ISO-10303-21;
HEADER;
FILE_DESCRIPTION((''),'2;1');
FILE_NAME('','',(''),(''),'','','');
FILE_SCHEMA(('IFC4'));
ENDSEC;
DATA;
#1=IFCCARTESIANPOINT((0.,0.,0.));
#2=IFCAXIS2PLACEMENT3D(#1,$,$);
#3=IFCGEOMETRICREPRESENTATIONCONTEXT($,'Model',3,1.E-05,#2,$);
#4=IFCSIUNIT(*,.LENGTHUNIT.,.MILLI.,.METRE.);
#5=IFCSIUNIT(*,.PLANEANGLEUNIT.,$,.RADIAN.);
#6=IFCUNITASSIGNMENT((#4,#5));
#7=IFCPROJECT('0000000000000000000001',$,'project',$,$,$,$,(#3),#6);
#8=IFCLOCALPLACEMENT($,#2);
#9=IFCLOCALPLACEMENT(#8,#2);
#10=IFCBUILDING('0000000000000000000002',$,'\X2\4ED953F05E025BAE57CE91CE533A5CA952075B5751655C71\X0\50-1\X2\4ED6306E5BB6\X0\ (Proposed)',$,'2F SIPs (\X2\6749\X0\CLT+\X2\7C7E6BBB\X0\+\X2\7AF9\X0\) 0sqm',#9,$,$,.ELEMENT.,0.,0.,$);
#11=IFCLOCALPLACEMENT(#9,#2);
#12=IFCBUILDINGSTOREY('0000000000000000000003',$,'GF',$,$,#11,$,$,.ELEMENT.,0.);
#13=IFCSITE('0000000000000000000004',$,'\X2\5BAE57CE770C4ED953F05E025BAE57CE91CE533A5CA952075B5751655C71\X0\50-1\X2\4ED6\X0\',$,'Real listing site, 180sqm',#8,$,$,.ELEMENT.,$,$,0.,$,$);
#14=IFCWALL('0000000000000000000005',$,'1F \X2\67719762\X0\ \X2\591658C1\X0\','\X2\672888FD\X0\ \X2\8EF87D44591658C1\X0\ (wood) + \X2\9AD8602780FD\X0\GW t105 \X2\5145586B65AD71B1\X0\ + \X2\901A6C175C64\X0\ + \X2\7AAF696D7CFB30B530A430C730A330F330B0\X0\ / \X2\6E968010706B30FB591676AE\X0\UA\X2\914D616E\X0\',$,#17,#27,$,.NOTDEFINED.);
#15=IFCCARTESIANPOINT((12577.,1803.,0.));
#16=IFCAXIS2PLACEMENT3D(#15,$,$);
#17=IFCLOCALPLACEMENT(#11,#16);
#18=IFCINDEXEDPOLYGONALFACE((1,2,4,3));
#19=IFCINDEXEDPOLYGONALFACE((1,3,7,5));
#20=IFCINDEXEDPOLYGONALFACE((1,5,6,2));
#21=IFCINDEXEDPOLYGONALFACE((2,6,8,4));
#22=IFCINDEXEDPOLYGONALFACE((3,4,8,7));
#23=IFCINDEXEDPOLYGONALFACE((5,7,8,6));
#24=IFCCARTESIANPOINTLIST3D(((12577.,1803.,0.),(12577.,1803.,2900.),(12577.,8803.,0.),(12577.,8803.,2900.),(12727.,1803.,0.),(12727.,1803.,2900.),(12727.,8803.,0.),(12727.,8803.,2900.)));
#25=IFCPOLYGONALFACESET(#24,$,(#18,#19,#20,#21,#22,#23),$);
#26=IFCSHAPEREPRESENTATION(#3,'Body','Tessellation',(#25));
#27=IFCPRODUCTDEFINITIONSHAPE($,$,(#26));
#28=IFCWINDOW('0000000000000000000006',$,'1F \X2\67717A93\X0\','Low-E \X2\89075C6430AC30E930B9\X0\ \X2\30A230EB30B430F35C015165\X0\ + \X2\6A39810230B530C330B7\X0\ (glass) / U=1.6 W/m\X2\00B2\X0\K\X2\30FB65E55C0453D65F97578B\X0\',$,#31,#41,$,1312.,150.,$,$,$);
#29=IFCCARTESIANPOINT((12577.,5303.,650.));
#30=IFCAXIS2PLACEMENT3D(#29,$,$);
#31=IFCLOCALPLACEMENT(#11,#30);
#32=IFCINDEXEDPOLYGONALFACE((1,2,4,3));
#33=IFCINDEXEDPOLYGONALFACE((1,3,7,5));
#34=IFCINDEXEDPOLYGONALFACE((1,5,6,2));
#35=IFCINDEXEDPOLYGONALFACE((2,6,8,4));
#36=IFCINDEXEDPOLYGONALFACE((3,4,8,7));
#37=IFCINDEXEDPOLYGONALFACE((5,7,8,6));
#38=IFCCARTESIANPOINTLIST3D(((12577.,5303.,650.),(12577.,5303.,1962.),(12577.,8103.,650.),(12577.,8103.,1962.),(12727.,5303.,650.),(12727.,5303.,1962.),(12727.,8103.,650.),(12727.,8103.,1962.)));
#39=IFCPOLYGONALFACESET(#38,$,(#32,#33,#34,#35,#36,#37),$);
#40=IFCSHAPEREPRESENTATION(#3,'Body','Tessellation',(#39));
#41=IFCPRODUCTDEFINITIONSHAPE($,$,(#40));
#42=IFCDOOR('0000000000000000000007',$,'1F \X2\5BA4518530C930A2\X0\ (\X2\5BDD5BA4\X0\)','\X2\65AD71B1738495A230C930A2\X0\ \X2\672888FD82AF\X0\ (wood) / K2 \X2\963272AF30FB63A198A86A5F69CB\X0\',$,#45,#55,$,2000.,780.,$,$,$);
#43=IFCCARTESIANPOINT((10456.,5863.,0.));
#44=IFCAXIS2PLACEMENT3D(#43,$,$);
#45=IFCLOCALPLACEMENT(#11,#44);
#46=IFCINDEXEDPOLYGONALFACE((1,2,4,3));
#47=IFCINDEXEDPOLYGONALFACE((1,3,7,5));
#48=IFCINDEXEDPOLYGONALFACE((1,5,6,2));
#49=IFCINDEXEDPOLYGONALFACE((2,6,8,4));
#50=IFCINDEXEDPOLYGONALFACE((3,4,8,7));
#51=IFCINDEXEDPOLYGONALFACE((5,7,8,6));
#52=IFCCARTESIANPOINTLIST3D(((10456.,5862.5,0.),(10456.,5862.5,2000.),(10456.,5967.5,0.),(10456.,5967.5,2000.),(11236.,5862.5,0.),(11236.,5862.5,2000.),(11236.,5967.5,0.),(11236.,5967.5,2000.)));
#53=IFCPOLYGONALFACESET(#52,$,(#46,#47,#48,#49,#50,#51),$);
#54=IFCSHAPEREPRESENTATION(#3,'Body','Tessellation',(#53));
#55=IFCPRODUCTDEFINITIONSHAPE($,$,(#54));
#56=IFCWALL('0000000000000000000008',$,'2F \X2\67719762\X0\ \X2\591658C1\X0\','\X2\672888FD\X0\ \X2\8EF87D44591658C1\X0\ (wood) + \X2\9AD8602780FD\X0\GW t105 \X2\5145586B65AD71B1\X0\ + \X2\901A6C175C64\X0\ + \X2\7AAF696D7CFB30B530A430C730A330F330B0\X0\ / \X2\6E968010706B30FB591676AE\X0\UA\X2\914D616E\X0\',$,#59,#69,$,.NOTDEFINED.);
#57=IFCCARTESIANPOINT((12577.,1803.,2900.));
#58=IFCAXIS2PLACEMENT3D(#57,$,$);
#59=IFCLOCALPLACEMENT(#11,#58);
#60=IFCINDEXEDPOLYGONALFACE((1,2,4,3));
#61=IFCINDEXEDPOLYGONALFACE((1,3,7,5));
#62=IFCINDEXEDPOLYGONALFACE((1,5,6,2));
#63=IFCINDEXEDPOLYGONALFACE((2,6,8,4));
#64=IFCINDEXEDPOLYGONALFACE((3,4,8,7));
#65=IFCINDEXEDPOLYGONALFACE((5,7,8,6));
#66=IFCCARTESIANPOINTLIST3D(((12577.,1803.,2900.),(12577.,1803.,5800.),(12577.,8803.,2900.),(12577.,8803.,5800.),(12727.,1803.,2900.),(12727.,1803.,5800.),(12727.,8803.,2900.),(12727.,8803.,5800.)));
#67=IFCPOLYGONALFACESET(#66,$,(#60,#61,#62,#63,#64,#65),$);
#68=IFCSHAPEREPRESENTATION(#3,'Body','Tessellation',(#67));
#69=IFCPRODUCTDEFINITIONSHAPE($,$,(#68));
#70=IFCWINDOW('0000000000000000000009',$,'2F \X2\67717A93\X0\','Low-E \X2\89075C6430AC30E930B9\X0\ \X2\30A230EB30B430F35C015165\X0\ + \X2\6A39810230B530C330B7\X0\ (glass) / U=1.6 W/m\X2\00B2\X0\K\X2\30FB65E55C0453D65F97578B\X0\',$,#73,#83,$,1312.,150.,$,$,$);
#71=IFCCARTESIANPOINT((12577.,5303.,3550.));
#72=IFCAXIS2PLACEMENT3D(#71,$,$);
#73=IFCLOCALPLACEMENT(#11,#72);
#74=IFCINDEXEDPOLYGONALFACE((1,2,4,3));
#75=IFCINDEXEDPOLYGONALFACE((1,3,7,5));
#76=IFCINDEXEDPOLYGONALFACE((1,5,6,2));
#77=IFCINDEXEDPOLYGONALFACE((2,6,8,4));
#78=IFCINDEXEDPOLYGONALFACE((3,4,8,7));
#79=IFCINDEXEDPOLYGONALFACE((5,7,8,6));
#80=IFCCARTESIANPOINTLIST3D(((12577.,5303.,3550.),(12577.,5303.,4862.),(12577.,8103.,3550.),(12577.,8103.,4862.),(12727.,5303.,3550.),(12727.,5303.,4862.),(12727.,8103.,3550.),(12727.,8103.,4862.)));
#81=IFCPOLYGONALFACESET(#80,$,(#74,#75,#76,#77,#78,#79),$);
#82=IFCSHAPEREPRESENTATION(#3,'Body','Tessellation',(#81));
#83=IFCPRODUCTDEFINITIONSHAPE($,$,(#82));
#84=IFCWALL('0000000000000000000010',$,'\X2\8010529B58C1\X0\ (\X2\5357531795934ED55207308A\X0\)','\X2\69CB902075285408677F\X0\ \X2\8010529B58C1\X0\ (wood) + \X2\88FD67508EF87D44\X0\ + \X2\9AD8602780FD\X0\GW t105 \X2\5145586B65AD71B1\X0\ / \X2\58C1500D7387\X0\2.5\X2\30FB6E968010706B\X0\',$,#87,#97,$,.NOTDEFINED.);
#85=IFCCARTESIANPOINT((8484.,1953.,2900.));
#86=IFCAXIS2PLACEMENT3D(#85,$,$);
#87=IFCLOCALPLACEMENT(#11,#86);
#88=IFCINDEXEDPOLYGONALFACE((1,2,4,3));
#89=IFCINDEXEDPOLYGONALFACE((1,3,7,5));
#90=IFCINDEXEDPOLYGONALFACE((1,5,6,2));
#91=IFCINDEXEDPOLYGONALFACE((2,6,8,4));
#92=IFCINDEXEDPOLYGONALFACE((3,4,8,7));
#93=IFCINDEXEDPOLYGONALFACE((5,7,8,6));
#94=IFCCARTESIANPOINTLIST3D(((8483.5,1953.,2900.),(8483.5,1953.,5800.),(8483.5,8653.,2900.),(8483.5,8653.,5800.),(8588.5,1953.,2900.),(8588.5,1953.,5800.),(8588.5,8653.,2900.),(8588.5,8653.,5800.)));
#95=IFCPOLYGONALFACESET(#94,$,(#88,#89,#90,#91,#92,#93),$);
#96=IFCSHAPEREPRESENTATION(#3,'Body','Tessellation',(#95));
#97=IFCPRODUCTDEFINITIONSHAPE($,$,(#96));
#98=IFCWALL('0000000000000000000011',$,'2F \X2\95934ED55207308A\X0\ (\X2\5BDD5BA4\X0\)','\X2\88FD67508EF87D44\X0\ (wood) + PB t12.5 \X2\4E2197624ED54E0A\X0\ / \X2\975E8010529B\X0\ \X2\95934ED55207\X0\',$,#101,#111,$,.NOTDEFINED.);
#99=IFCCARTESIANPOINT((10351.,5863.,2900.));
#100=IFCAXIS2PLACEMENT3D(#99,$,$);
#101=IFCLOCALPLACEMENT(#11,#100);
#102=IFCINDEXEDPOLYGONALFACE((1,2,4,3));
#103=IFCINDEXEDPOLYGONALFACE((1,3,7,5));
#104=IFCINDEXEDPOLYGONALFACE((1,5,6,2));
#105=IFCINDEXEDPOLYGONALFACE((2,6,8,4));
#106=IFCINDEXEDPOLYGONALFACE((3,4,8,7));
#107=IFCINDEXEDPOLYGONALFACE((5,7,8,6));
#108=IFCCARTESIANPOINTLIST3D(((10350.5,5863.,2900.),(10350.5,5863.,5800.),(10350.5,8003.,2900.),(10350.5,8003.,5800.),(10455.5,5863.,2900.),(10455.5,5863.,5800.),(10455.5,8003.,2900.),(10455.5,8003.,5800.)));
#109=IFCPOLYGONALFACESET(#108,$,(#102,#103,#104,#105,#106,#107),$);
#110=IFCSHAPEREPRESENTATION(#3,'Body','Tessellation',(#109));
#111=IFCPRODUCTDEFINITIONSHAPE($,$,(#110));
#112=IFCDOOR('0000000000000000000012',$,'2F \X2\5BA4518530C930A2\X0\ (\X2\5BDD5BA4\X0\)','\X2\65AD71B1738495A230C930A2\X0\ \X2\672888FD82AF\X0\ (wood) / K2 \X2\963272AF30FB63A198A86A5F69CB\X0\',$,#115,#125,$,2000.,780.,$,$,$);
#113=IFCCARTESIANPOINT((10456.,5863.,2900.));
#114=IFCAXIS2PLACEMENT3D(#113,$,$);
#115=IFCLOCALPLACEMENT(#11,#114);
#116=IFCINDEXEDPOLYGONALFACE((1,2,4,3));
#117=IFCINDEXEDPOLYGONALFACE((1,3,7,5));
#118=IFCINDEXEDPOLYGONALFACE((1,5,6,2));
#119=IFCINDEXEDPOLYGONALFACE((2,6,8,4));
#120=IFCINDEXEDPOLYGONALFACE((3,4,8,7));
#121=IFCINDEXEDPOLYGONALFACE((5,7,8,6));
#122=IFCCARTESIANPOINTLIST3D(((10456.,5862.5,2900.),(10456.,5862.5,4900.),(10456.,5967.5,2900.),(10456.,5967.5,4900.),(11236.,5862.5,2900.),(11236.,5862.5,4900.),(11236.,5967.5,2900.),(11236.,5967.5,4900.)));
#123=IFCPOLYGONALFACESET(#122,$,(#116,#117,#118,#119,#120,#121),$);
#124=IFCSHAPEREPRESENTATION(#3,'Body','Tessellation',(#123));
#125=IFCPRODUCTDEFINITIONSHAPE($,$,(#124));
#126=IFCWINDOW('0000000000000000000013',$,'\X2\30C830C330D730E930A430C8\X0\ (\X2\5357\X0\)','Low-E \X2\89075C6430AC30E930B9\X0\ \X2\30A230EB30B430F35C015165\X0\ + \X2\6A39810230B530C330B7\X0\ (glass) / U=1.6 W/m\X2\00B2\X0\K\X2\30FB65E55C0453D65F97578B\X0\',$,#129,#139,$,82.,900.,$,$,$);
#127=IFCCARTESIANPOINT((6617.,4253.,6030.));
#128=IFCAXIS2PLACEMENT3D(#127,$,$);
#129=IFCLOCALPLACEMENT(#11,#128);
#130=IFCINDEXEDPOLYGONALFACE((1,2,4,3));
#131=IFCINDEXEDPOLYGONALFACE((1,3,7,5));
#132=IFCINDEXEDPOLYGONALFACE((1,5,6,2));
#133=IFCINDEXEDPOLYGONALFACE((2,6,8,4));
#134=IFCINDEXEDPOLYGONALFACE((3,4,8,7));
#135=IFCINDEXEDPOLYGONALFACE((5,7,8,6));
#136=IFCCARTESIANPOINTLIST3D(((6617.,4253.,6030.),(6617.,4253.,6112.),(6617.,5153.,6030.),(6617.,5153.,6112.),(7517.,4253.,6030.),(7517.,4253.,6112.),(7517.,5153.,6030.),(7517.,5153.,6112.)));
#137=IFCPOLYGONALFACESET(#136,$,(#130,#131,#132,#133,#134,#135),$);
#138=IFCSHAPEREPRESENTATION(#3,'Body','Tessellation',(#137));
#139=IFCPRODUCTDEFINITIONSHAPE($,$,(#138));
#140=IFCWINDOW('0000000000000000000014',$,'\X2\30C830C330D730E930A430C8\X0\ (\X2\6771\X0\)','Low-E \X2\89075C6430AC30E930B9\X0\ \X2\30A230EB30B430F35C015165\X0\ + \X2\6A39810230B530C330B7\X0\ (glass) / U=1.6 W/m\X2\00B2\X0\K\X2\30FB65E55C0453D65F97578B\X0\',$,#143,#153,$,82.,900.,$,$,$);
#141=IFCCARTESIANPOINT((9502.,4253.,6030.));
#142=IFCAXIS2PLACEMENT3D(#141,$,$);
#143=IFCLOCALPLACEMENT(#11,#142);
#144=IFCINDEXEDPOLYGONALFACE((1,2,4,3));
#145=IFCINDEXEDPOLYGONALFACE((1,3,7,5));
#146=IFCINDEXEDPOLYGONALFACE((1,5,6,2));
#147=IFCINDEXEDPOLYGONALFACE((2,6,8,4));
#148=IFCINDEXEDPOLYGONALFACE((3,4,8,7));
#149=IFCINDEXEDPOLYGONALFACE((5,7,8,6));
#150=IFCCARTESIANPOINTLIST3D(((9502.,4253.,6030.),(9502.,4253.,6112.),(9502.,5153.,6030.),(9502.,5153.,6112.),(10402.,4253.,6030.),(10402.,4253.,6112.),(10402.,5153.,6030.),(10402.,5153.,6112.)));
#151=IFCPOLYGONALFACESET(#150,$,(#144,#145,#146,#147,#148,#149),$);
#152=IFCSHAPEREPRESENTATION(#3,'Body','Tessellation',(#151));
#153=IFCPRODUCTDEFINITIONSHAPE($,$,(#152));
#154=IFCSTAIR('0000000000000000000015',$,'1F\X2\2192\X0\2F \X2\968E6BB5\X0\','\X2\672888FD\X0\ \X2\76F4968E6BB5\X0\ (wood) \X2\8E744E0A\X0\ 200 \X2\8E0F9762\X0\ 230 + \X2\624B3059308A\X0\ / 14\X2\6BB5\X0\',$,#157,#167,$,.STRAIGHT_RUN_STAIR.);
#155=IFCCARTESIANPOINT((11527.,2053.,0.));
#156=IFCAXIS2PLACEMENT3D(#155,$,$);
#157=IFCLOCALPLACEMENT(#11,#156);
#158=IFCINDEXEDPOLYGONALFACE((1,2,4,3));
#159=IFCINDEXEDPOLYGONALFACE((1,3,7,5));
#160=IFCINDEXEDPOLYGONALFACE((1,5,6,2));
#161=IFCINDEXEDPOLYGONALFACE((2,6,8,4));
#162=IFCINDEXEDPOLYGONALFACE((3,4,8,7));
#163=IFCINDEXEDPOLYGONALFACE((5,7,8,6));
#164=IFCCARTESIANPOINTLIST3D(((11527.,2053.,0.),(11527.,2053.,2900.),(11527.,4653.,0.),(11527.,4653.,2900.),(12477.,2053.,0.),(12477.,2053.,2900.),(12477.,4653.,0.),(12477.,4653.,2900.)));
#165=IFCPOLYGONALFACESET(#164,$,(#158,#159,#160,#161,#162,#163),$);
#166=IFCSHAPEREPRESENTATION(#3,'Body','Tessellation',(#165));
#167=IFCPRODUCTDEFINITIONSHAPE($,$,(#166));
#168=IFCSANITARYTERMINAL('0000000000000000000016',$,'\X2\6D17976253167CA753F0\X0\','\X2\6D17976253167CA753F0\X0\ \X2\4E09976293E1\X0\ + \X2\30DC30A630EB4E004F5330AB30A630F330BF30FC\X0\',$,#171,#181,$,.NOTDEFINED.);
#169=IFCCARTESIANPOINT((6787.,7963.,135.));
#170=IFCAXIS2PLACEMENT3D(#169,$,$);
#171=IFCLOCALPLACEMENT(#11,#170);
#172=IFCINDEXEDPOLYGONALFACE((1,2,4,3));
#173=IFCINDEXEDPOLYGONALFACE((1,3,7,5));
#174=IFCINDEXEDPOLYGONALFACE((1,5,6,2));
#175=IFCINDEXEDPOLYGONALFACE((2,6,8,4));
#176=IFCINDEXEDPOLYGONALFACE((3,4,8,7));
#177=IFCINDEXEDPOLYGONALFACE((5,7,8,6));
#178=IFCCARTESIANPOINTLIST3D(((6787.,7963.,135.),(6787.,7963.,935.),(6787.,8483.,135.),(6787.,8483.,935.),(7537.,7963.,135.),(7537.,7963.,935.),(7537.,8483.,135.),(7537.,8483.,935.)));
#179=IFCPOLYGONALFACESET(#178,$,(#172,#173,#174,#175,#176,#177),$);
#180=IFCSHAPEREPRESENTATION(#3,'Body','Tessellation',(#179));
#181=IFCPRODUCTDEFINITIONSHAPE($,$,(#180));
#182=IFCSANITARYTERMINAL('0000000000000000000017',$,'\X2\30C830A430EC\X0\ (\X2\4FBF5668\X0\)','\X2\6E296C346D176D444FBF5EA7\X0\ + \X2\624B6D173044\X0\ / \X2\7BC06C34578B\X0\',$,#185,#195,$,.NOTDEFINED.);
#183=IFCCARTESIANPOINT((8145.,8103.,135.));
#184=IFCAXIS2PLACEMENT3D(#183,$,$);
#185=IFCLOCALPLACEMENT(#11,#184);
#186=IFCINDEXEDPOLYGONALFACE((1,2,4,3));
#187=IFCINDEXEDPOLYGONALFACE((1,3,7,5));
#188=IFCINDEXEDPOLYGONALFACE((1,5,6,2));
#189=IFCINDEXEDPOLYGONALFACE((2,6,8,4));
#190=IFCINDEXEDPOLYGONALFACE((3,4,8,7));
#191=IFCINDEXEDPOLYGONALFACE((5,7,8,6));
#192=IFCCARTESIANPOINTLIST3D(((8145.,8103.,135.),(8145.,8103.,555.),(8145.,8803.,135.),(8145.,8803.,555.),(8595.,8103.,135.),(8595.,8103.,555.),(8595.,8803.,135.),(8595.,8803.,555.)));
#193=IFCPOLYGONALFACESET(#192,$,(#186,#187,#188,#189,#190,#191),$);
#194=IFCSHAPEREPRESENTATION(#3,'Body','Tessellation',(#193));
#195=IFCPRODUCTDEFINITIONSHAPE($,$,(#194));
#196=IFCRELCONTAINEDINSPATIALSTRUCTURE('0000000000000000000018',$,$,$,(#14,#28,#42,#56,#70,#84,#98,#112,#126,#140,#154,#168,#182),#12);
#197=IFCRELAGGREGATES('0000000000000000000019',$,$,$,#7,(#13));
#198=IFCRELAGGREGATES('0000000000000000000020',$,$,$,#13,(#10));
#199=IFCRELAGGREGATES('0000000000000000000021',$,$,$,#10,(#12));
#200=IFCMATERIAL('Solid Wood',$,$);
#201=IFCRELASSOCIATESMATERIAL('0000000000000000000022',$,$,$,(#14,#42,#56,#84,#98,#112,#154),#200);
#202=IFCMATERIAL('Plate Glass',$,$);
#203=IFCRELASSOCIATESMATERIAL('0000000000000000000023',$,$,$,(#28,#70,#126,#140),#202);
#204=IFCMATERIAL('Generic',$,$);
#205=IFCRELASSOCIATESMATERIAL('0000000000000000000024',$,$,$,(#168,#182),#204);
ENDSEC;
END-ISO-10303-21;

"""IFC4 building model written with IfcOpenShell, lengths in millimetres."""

from ifc_helpers import new_model, si_unit, frame, frame_2d, origin, place, context, project, spatial, rectangle, extrude, material, element, fill, save


model = new_model("IFC4")

# Units and contexts
model_context = context("Model", 3, precision=1e-05, world=origin())
ifc_project = project(units=[si_unit("LENGTHUNIT", "METRE", prefix="MILLI"), si_unit("PLANEANGLEUNIT", "RADIAN")], contexts=[model_context])

# Site, building, storey
site_placement = place(None, origin())
site = spatial("IfcSite", under=ifc_project, at=site_placement, Name="宮城県仙台市宮城野区岩切字入山50-1他", ObjectType="Real listing site, 180sqm", CompositionType="ELEMENT", RefElevation=0.0)
building_placement = place(site_placement, origin())
building = spatial("IfcBuilding", under=site, at=building_placement, Name="仙台市宮城野区岩切字入山50-1他の家 (Proposed)", ObjectType="2F SIPs (杉CLT+籾殻+竹) 0sqm", CompositionType="ELEMENT", ElevationOfRefHeight=0.0, ElevationOfTerrain=0.0)
storey_placement = place(building_placement, origin())
storey = spatial("IfcBuildingStorey", under=building, at=storey_placement, Name="GF", CompositionType="ELEMENT", Elevation=0.0)

# Wall, opening, window
ifc_material_1 = material(Name="Solid Wood")
wall_1_placement = place(storey_placement, frame((12577.0, 1803.0, 0.0)))
wall_1 = element("IfcWall", 1, at=wall_1_placement, inside=storey, material=ifc_material_1, Name="1F 東面 外壁", Description="木製 軸組外壁 (wood) + 高性能GW t105 充填断熱 + 通気層 + 窯業系サイディング / 準耐火・外皮UA配慮", PredefinedType="NOTDEFINED", context=model_context, shape_type="SweptSolid", body=[
    extrude(rectangle(XDim=150.0, YDim=7000.0, at=frame_2d((75.0, 3500.0))), frame((12577.0, 1803.0, 0.0)), (0.0, 0.0, 1.0), 2900.0),
])
opening_1_placement = place(storey_placement, frame((12577.0, 5303.0, 650.0)))
opening_1 = element("IfcOpeningElement", 2, at=opening_1_placement, cuts=wall_1, PredefinedType="NOTDEFINED", context=model_context, shape_type="SweptSolid", body=[
    extrude(rectangle(XDim=150.0, YDim=2800.0, at=frame_2d((75.0, 1400.0))), frame((12577.0, 5303.0, 650.0)), (0.0, 0.0, 1.0), 1312.0),
])
ifc_material_2 = material(Name="Plate Glass")
window_1_placement = place(storey_placement, frame((12577.0, 5303.0, 650.0)))
window_1 = element("IfcWindow", 3, at=window_1_placement, inside=storey, material=ifc_material_2, Name="1F 東窓", Description="Low-E 複層ガラス アルゴン封入 + 樹脂サッシ (glass) / U=1.6 W/m²K・日射取得型", OverallHeight=1312.0, OverallWidth=150.0, context=model_context, shape_type="SweptSolid", body=[
    extrude(rectangle(XDim=150.0, YDim=2800.0, at=frame_2d((75.0, 1400.0))), frame((12577.0, 5303.0, 650.0)), (0.0, 0.0, 1.0), 1312.0),
])
fill(opening_1, window_1)

# Door
door_1_placement = place(storey_placement, frame((10456.0, 5863.0, 0.0)))
element("IfcDoor", 4, at=door_1_placement, inside=storey, material=ifc_material_1, Name="1F 室内ドア (寝室)", Description="断熱玄関ドア 木製芯 (wood) / K2 防犯・採風機構", OverallHeight=2000.0, OverallWidth=780.0, context=model_context, shape_type="SweptSolid", body=[
    extrude(rectangle(XDim=780.0, YDim=105.0, at=frame_2d((390.0, 52.0))), frame((10456.0, 5863.0, 0.0)), (0.0, 0.0, 1.0), 2000.0),
])

# Wall, opening, window
wall_2_placement = place(storey_placement, frame((12577.0, 1803.0, 2900.0)))
wall_2 = element("IfcWall", 5, at=wall_2_placement, inside=storey, material=ifc_material_1, Name="2F 東面 外壁", Description="木製 軸組外壁 (wood) + 高性能GW t105 充填断熱 + 通気層 + 窯業系サイディング / 準耐火・外皮UA配慮", PredefinedType="NOTDEFINED", context=model_context, shape_type="SweptSolid", body=[
    extrude(rectangle(XDim=150.0, YDim=7000.0, at=frame_2d((75.0, 3500.0))), frame((12577.0, 1803.0, 2900.0)), (0.0, 0.0, 1.0), 2900.0),
])
opening_2_placement = place(storey_placement, frame((12577.0, 5303.0, 3550.0)))
opening_2 = element("IfcOpeningElement", 6, at=opening_2_placement, cuts=wall_2, PredefinedType="NOTDEFINED", context=model_context, shape_type="SweptSolid", body=[
    extrude(rectangle(XDim=150.0, YDim=2800.0, at=frame_2d((75.0, 1400.0))), frame((12577.0, 5303.0, 3550.0)), (0.0, 0.0, 1.0), 1312.0),
])
window_2_placement = place(storey_placement, frame((12577.0, 5303.0, 3550.0)))
window_2 = element("IfcWindow", 7, at=window_2_placement, inside=storey, material=ifc_material_2, Name="2F 東窓", Description="Low-E 複層ガラス アルゴン封入 + 樹脂サッシ (glass) / U=1.6 W/m²K・日射取得型", OverallHeight=1312.0, OverallWidth=150.0, context=model_context, shape_type="SweptSolid", body=[
    extrude(rectangle(XDim=150.0, YDim=2800.0, at=frame_2d((75.0, 1400.0))), frame((12577.0, 5303.0, 3550.0)), (0.0, 0.0, 1.0), 1312.0),
])
fill(opening_2, window_2)

# Walls
wall_3_placement = place(storey_placement, frame((8484.0, 1953.0, 2900.0)))
element("IfcWall", 8, at=wall_3_placement, inside=storey, material=ifc_material_1, Name="耐力壁 (南北間仕切り)", Description="構造用合板 耐力壁 (wood) + 製材軸組 + 高性能GW t105 充填断熱 / 壁倍率2.5・準耐火", PredefinedType="NOTDEFINED", context=model_context, shape_type="SweptSolid", body=[
    extrude(rectangle(XDim=105.0, YDim=6700.0, at=frame_2d((52.0, 3350.0))), frame((8484.0, 1953.0, 2900.0)), (0.0, 0.0, 1.0), 2900.0),
])
wall_4_placement = place(storey_placement, frame((10351.0, 5863.0, 2900.0)))
element("IfcWall", 9, at=wall_4_placement, inside=storey, material=ifc_material_1, Name="2F 間仕切り (寝室)", Description="製材軸組 (wood) + PB t12.5 両面仕上 / 非耐力 間仕切", PredefinedType="NOTDEFINED", context=model_context, shape_type="SweptSolid", body=[
    extrude(rectangle(XDim=105.0, YDim=2140.0, at=frame_2d((52.0, 1070.0))), frame((10351.0, 5863.0, 2900.0)), (0.0, 0.0, 1.0), 2900.0),
])

# Door
door_2_placement = place(storey_placement, frame((10456.0, 5863.0, 2900.0)))
element("IfcDoor", 10, at=door_2_placement, inside=storey, material=ifc_material_1, Name="2F 室内ドア (寝室)", Description="断熱玄関ドア 木製芯 (wood) / K2 防犯・採風機構", OverallHeight=2000.0, OverallWidth=780.0, context=model_context, shape_type="SweptSolid", body=[
    extrude(rectangle(XDim=780.0, YDim=105.0, at=frame_2d((390.0, 52.0))), frame((10456.0, 5863.0, 2900.0)), (0.0, 0.0, 1.0), 2000.0),
])

# Windows
window_3_placement = place(storey_placement, frame((6617.0, 4253.0, 6030.0)))
element("IfcWindow", 11, at=window_3_placement, inside=storey, material=ifc_material_2, Name="トップライト (南)", Description="Low-E 複層ガラス アルゴン封入 + 樹脂サッシ (glass) / U=1.6 W/m²K・日射取得型", OverallHeight=82.0, OverallWidth=900.0, context=model_context, shape_type="SweptSolid", body=[
    extrude(rectangle(XDim=900.0, YDim=900.0, at=frame_2d((450.0, 450.0))), frame((6617.0, 4253.0, 6030.0)), (0.0, 0.0, 1.0), 82.0),
])
window_4_placement = place(storey_placement, frame((9502.0, 4253.0, 6030.0)))
element("IfcWindow", 12, at=window_4_placement, inside=storey, material=ifc_material_2, Name="トップライト (東)", Description="Low-E 複層ガラス アルゴン封入 + 樹脂サッシ (glass) / U=1.6 W/m²K・日射取得型", OverallHeight=82.0, OverallWidth=900.0, context=model_context, shape_type="SweptSolid", body=[
    extrude(rectangle(XDim=900.0, YDim=900.0, at=frame_2d((450.0, 450.0))), frame((9502.0, 4253.0, 6030.0)), (0.0, 0.0, 1.0), 82.0),
])

# Stair
stair_placement = place(storey_placement, frame((11527.0, 2053.0, 0.0)))
element("IfcStair", 13, at=stair_placement, inside=storey, material=ifc_material_1, Name="1F→2F 階段", Description="木製 直階段 (wood) 蹴上 200 踏面 230 + 手すり / 14段", PredefinedType="STRAIGHT_RUN_STAIR", context=model_context, shape_type="SweptSolid", body=[
    extrude(rectangle(XDim=950.0, YDim=2600.0, at=frame_2d((475.0, 1300.0))), frame((11527.0, 2053.0, 0.0)), (0.0, 0.0, 1.0), 2900.0),
])

# Sanitary terminals
ifc_material_3 = material(Name="Generic")
sanitary_terminal_1_placement = place(storey_placement, frame((6787.0, 7963.0, 135.0)))
element("IfcSanitaryTerminal", 14, at=sanitary_terminal_1_placement, inside=storey, material=ifc_material_3, Name="洗面化粧台", Description="洗面化粧台 三面鏡 + ボウル一体カウンター", PredefinedType="NOTDEFINED", context=model_context, shape_type="SweptSolid", body=[
    extrude(rectangle(XDim=750.0, YDim=520.0, at=frame_2d((375.0, 260.0))), frame((6787.0, 7963.0, 135.0)), (0.0, 0.0, 1.0), 800.0),
])
sanitary_terminal_2_placement = place(storey_placement, frame((8145.0, 8103.0, 135.0)))
element("IfcSanitaryTerminal", 15, at=sanitary_terminal_2_placement, inside=storey, material=ifc_material_3, Name="トイレ (便器)", Description="温水洗浄便座 + 手洗い / 節水型", PredefinedType="NOTDEFINED", context=model_context, shape_type="SweptSolid", body=[
    extrude(rectangle(XDim=450.0, YDim=700.0, at=frame_2d((225.0, 350.0))), frame((8145.0, 8103.0, 135.0)), (0.0, 0.0, 1.0), 420.0),
])

save(model, "model.ifc")
